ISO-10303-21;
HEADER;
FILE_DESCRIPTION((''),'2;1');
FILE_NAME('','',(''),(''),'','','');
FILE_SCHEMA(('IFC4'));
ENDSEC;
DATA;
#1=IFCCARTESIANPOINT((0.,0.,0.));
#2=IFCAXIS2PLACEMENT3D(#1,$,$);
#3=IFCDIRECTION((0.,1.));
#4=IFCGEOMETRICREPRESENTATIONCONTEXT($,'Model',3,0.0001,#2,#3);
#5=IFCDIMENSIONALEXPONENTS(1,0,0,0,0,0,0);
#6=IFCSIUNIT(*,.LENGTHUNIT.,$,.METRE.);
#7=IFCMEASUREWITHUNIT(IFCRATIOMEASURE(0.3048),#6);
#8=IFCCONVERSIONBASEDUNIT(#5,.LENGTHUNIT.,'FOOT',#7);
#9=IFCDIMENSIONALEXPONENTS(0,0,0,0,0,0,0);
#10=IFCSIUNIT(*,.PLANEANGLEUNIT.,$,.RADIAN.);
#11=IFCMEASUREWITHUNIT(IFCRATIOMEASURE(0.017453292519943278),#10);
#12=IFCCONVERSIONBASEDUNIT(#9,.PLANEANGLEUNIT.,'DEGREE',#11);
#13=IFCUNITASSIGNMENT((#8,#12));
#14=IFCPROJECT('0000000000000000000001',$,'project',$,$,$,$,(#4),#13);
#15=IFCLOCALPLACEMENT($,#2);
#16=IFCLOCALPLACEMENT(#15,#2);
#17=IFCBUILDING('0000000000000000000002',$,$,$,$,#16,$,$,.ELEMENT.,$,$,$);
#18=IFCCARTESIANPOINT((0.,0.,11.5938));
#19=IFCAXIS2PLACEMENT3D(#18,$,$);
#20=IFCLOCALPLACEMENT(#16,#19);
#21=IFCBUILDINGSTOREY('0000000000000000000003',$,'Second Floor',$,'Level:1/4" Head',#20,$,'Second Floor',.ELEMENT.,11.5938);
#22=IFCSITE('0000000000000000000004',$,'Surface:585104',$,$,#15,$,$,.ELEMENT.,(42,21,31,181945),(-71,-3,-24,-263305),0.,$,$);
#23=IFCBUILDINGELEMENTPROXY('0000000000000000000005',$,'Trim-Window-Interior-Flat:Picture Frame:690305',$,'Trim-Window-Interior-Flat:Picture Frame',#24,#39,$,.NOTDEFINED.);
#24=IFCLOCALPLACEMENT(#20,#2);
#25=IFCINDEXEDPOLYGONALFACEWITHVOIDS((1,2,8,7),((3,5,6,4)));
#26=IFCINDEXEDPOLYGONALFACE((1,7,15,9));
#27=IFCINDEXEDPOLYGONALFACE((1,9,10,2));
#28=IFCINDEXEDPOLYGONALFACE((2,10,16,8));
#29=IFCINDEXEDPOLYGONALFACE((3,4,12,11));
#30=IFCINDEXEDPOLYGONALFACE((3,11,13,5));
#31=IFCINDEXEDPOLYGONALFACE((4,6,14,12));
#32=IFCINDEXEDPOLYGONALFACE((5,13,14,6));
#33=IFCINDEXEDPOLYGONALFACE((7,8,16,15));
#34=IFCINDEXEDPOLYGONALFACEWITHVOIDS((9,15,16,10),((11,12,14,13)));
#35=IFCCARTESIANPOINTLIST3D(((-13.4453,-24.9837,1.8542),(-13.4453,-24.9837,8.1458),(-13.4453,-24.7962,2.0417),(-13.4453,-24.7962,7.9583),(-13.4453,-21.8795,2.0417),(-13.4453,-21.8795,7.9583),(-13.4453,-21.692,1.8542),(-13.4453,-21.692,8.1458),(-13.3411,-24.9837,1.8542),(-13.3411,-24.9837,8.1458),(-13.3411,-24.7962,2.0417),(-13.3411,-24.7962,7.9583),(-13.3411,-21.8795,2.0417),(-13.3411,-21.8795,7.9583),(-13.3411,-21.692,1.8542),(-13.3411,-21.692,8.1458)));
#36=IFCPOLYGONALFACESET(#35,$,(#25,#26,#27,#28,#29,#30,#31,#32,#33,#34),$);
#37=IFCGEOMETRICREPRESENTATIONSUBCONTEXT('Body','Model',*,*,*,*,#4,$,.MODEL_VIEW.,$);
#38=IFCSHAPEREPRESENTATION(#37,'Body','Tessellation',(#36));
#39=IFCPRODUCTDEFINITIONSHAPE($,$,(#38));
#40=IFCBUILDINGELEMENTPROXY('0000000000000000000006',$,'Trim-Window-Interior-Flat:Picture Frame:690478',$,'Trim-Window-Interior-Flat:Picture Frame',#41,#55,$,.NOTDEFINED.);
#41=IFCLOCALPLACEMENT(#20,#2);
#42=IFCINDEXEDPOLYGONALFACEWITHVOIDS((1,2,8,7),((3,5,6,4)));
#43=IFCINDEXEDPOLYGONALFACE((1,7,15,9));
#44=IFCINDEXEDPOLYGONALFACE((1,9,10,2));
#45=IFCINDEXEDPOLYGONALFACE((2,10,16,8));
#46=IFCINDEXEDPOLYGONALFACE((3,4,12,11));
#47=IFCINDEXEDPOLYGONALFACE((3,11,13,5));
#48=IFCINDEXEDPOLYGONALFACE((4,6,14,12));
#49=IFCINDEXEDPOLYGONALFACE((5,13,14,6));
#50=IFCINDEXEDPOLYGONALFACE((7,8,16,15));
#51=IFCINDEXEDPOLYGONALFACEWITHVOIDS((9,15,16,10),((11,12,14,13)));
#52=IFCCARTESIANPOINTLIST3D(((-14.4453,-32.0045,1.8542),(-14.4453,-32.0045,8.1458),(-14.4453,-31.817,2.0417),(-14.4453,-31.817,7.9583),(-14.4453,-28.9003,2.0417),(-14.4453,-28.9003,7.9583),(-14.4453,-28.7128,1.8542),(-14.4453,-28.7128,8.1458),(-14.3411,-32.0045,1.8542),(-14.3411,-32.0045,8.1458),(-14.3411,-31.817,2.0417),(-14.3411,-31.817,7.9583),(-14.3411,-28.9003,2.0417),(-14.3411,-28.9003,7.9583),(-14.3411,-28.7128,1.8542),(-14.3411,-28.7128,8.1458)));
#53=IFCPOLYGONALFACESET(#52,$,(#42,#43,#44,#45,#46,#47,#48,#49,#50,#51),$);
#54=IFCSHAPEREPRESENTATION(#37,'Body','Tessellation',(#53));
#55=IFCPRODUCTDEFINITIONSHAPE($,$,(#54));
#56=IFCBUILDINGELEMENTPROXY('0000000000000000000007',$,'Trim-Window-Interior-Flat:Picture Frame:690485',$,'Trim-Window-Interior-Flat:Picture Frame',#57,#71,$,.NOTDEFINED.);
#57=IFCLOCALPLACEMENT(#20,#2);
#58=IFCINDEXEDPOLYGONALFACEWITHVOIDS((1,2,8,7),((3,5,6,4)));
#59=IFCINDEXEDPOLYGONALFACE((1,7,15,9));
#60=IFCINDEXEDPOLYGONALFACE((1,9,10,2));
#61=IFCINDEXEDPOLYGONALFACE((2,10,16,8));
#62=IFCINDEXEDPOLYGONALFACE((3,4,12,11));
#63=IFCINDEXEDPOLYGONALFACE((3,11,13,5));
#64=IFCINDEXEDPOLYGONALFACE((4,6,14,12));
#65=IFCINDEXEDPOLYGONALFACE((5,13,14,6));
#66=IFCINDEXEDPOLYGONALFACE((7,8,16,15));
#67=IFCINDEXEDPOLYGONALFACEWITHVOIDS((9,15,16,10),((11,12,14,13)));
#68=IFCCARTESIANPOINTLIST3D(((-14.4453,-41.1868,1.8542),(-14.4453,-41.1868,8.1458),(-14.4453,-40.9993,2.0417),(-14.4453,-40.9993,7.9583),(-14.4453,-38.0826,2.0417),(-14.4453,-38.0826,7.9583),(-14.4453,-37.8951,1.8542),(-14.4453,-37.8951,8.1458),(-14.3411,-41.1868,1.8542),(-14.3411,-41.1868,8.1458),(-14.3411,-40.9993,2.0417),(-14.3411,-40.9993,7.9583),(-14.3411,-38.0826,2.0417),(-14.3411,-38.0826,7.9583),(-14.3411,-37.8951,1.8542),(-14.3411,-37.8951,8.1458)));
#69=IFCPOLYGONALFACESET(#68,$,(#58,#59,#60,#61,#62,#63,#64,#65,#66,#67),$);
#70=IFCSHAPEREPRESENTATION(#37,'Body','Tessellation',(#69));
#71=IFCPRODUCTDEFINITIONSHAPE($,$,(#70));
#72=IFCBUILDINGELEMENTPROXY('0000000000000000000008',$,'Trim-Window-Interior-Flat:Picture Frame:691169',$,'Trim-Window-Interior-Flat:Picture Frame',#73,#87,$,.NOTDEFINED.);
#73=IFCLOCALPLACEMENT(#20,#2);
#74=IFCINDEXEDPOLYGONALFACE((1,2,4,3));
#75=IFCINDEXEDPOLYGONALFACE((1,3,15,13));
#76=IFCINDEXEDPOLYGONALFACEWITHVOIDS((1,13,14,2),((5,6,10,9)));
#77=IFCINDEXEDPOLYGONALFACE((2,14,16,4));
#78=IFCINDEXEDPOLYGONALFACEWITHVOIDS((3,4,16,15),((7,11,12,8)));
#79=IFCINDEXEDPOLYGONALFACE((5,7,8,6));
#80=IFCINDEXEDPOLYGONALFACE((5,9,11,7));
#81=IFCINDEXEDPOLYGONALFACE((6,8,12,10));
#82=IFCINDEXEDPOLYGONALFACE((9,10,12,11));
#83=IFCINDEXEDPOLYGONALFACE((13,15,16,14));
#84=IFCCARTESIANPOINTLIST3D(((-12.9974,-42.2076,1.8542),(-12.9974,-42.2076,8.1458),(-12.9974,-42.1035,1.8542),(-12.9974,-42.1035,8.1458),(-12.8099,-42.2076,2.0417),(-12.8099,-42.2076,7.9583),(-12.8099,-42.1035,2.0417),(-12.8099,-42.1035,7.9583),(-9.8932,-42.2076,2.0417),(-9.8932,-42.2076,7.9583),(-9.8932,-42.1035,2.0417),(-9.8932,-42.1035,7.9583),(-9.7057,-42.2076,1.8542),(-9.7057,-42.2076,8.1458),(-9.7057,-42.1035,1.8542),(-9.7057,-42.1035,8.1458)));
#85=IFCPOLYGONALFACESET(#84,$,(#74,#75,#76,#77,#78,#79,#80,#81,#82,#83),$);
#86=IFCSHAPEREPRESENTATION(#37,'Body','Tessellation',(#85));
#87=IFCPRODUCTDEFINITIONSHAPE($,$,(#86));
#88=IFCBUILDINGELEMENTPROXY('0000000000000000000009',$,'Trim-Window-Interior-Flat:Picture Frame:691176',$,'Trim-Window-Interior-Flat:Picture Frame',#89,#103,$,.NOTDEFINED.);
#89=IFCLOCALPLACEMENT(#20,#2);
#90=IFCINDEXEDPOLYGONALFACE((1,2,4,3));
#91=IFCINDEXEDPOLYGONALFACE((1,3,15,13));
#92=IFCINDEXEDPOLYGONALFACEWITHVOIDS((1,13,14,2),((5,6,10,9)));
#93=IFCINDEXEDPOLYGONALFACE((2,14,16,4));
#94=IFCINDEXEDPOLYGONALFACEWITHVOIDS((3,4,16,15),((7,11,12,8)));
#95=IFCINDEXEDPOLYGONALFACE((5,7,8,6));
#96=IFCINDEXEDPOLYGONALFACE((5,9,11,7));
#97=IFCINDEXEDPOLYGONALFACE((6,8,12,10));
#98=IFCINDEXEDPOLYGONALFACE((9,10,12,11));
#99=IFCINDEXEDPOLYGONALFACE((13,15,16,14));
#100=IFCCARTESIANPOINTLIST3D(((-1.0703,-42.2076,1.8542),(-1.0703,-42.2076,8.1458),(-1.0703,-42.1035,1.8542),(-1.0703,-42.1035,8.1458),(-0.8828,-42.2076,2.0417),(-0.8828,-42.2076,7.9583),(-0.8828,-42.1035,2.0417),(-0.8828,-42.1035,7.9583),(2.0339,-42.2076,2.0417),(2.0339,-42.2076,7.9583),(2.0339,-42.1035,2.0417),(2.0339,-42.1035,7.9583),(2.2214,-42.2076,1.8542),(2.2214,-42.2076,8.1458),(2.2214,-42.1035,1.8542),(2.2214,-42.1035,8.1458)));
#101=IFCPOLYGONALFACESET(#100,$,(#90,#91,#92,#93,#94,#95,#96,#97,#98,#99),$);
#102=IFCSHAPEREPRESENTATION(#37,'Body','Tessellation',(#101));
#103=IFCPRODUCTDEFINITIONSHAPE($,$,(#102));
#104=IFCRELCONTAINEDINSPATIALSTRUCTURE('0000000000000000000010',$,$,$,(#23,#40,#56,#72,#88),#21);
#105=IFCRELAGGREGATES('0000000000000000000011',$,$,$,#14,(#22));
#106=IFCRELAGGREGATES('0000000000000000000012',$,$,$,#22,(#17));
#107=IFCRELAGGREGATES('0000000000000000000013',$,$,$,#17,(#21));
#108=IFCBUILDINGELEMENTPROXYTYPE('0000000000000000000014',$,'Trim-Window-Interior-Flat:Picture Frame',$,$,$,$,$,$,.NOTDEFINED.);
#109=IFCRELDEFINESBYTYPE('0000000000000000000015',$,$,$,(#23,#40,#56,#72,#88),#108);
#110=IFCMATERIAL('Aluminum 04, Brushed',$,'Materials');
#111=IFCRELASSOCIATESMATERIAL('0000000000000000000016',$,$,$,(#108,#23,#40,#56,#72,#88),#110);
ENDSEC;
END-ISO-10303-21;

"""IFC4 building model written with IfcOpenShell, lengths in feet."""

from ifc_helpers import new_model, entity, si_unit, converted_unit, direction, frame, origin, place, context, subcontext, project, spatial, indexed_curve, outline, extrude, source, transform, mapped, material, type_object, type_shapes, element, save


model = new_model("IFC4")

# Units and contexts
model_context = context("Model", 3, precision=0.0001, world=origin(), true_north=direction((0.0, 1.0)))
body_context = subcontext(model_context, "Body", "Model", "MODEL_VIEW")
ifc_project = project(units=[converted_unit("LENGTHUNIT", "FOOT", entity("IfcRatioMeasure", 0.3048), si_unit("LENGTHUNIT", "METRE"), dimensions=[1, 0, 0, 0, 0, 0, 0]), converted_unit("PLANEANGLEUNIT", "DEGREE", entity("IfcRatioMeasure", 0.017453292519943278), si_unit("PLANEANGLEUNIT", "RADIAN"), dimensions=[0, 0, 0, 0, 0, 0, 0])], contexts=[model_context])

# Site, building, storey
site_placement = place(None, origin())
site = spatial("IfcSite", under=ifc_project, at=site_placement, Name="Surface:585104", CompositionType="ELEMENT", RefLatitude=(42, 21, 31, 181945), RefLongitude=(-71, -3, -24, -263305), RefElevation=0.0)
building_placement = place(site_placement, origin())
building = spatial("IfcBuilding", under=site, at=building_placement, CompositionType="ELEMENT")
storey_placement = place(building_placement, frame((0.0, 0.0, 11.5938)))
storey = spatial("IfcBuildingStorey", under=building, at=storey_placement, Name="Second Floor", ObjectType="Level:1/4\" Head", LongName="Second Floor", CompositionType="ELEMENT", Elevation=11.5938)

# Building element proxies
ifc_material_1 = material(Name="Aluminum 04, Brushed", Category="Materials")
building_element_proxy_type_1 = type_object("IfcBuildingElementProxyType", Name="Trim-Window-Interior-Flat:Picture Frame", PredefinedType="NOTDEFINED", material=ifc_material_1)
shared_shape_1 = source(origin(), body_context, "Body", "SweptSolid", [
    extrude(outline(indexed_curve([(-3.1458, -1.6458), (3.1458, -1.6458), (3.1458, 1.6458), (-3.1458, 1.6458), (-3.1458, -1.6458)], self_intersect=False), holes=[indexed_curve([(-2.9583, -1.4583), (-2.9583, 1.4583), (2.9583, 1.4583), (2.9583, -1.4583), (-2.9583, -1.4583)], self_intersect=False)]), frame((0.0, 3.0, 0.0), z_axis=(0.0, 0.0, 1.0), x_axis=(0.0, 1.0, 0.0)), (0.0, 0.0, 1.0), 0.1042),
])
type_shapes(building_element_proxy_type_1, [shared_shape_1])
for number, where, z_axis, x_axis, name in (
    (1, (-13.3411, -23.3378, 8.0), (-1.0, 0.0, 0.0), (0.0, 1.0, 0.0), "Trim-Window-Interior-Flat:Picture Frame:690305"),
    (2, (-14.3411, -30.3587, 8.0), (-1.0, 0.0, 0.0), (0.0, 1.0, 0.0), "Trim-Window-Interior-Flat:Picture Frame:690478"),
    (3, (-14.3411, -39.541, 8.0), (-1.0, 0.0, 0.0), (0.0, 1.0, 0.0), "Trim-Window-Interior-Flat:Picture Frame:690485"),
    (4, (-11.3515, -42.1035, 8.0), (0.0, -1.0, 0.0), (-1.0, 0.0, 0.0), "Trim-Window-Interior-Flat:Picture Frame:691169"),
    (5, (0.5755, -42.1035, 8.0), (0.0, -1.0, 0.0), (-1.0, 0.0, 0.0), "Trim-Window-Interior-Flat:Picture Frame:691176"),
):
    element("IfcBuildingElementProxy", number, at=place(storey_placement, frame(where, z_axis=z_axis, x_axis=x_axis)), inside=storey, type_object=building_element_proxy_type_1, material=ifc_material_1, Name=name, ObjectType="Trim-Window-Interior-Flat:Picture Frame", PredefinedType="NOTDEFINED", context=body_context, shape_type="MappedRepresentation", body=[
        mapped(shared_shape_1, transform((0.0, 0.0, 0.0), scale=1.0)),
    ])

save(model, "model.ifc")
